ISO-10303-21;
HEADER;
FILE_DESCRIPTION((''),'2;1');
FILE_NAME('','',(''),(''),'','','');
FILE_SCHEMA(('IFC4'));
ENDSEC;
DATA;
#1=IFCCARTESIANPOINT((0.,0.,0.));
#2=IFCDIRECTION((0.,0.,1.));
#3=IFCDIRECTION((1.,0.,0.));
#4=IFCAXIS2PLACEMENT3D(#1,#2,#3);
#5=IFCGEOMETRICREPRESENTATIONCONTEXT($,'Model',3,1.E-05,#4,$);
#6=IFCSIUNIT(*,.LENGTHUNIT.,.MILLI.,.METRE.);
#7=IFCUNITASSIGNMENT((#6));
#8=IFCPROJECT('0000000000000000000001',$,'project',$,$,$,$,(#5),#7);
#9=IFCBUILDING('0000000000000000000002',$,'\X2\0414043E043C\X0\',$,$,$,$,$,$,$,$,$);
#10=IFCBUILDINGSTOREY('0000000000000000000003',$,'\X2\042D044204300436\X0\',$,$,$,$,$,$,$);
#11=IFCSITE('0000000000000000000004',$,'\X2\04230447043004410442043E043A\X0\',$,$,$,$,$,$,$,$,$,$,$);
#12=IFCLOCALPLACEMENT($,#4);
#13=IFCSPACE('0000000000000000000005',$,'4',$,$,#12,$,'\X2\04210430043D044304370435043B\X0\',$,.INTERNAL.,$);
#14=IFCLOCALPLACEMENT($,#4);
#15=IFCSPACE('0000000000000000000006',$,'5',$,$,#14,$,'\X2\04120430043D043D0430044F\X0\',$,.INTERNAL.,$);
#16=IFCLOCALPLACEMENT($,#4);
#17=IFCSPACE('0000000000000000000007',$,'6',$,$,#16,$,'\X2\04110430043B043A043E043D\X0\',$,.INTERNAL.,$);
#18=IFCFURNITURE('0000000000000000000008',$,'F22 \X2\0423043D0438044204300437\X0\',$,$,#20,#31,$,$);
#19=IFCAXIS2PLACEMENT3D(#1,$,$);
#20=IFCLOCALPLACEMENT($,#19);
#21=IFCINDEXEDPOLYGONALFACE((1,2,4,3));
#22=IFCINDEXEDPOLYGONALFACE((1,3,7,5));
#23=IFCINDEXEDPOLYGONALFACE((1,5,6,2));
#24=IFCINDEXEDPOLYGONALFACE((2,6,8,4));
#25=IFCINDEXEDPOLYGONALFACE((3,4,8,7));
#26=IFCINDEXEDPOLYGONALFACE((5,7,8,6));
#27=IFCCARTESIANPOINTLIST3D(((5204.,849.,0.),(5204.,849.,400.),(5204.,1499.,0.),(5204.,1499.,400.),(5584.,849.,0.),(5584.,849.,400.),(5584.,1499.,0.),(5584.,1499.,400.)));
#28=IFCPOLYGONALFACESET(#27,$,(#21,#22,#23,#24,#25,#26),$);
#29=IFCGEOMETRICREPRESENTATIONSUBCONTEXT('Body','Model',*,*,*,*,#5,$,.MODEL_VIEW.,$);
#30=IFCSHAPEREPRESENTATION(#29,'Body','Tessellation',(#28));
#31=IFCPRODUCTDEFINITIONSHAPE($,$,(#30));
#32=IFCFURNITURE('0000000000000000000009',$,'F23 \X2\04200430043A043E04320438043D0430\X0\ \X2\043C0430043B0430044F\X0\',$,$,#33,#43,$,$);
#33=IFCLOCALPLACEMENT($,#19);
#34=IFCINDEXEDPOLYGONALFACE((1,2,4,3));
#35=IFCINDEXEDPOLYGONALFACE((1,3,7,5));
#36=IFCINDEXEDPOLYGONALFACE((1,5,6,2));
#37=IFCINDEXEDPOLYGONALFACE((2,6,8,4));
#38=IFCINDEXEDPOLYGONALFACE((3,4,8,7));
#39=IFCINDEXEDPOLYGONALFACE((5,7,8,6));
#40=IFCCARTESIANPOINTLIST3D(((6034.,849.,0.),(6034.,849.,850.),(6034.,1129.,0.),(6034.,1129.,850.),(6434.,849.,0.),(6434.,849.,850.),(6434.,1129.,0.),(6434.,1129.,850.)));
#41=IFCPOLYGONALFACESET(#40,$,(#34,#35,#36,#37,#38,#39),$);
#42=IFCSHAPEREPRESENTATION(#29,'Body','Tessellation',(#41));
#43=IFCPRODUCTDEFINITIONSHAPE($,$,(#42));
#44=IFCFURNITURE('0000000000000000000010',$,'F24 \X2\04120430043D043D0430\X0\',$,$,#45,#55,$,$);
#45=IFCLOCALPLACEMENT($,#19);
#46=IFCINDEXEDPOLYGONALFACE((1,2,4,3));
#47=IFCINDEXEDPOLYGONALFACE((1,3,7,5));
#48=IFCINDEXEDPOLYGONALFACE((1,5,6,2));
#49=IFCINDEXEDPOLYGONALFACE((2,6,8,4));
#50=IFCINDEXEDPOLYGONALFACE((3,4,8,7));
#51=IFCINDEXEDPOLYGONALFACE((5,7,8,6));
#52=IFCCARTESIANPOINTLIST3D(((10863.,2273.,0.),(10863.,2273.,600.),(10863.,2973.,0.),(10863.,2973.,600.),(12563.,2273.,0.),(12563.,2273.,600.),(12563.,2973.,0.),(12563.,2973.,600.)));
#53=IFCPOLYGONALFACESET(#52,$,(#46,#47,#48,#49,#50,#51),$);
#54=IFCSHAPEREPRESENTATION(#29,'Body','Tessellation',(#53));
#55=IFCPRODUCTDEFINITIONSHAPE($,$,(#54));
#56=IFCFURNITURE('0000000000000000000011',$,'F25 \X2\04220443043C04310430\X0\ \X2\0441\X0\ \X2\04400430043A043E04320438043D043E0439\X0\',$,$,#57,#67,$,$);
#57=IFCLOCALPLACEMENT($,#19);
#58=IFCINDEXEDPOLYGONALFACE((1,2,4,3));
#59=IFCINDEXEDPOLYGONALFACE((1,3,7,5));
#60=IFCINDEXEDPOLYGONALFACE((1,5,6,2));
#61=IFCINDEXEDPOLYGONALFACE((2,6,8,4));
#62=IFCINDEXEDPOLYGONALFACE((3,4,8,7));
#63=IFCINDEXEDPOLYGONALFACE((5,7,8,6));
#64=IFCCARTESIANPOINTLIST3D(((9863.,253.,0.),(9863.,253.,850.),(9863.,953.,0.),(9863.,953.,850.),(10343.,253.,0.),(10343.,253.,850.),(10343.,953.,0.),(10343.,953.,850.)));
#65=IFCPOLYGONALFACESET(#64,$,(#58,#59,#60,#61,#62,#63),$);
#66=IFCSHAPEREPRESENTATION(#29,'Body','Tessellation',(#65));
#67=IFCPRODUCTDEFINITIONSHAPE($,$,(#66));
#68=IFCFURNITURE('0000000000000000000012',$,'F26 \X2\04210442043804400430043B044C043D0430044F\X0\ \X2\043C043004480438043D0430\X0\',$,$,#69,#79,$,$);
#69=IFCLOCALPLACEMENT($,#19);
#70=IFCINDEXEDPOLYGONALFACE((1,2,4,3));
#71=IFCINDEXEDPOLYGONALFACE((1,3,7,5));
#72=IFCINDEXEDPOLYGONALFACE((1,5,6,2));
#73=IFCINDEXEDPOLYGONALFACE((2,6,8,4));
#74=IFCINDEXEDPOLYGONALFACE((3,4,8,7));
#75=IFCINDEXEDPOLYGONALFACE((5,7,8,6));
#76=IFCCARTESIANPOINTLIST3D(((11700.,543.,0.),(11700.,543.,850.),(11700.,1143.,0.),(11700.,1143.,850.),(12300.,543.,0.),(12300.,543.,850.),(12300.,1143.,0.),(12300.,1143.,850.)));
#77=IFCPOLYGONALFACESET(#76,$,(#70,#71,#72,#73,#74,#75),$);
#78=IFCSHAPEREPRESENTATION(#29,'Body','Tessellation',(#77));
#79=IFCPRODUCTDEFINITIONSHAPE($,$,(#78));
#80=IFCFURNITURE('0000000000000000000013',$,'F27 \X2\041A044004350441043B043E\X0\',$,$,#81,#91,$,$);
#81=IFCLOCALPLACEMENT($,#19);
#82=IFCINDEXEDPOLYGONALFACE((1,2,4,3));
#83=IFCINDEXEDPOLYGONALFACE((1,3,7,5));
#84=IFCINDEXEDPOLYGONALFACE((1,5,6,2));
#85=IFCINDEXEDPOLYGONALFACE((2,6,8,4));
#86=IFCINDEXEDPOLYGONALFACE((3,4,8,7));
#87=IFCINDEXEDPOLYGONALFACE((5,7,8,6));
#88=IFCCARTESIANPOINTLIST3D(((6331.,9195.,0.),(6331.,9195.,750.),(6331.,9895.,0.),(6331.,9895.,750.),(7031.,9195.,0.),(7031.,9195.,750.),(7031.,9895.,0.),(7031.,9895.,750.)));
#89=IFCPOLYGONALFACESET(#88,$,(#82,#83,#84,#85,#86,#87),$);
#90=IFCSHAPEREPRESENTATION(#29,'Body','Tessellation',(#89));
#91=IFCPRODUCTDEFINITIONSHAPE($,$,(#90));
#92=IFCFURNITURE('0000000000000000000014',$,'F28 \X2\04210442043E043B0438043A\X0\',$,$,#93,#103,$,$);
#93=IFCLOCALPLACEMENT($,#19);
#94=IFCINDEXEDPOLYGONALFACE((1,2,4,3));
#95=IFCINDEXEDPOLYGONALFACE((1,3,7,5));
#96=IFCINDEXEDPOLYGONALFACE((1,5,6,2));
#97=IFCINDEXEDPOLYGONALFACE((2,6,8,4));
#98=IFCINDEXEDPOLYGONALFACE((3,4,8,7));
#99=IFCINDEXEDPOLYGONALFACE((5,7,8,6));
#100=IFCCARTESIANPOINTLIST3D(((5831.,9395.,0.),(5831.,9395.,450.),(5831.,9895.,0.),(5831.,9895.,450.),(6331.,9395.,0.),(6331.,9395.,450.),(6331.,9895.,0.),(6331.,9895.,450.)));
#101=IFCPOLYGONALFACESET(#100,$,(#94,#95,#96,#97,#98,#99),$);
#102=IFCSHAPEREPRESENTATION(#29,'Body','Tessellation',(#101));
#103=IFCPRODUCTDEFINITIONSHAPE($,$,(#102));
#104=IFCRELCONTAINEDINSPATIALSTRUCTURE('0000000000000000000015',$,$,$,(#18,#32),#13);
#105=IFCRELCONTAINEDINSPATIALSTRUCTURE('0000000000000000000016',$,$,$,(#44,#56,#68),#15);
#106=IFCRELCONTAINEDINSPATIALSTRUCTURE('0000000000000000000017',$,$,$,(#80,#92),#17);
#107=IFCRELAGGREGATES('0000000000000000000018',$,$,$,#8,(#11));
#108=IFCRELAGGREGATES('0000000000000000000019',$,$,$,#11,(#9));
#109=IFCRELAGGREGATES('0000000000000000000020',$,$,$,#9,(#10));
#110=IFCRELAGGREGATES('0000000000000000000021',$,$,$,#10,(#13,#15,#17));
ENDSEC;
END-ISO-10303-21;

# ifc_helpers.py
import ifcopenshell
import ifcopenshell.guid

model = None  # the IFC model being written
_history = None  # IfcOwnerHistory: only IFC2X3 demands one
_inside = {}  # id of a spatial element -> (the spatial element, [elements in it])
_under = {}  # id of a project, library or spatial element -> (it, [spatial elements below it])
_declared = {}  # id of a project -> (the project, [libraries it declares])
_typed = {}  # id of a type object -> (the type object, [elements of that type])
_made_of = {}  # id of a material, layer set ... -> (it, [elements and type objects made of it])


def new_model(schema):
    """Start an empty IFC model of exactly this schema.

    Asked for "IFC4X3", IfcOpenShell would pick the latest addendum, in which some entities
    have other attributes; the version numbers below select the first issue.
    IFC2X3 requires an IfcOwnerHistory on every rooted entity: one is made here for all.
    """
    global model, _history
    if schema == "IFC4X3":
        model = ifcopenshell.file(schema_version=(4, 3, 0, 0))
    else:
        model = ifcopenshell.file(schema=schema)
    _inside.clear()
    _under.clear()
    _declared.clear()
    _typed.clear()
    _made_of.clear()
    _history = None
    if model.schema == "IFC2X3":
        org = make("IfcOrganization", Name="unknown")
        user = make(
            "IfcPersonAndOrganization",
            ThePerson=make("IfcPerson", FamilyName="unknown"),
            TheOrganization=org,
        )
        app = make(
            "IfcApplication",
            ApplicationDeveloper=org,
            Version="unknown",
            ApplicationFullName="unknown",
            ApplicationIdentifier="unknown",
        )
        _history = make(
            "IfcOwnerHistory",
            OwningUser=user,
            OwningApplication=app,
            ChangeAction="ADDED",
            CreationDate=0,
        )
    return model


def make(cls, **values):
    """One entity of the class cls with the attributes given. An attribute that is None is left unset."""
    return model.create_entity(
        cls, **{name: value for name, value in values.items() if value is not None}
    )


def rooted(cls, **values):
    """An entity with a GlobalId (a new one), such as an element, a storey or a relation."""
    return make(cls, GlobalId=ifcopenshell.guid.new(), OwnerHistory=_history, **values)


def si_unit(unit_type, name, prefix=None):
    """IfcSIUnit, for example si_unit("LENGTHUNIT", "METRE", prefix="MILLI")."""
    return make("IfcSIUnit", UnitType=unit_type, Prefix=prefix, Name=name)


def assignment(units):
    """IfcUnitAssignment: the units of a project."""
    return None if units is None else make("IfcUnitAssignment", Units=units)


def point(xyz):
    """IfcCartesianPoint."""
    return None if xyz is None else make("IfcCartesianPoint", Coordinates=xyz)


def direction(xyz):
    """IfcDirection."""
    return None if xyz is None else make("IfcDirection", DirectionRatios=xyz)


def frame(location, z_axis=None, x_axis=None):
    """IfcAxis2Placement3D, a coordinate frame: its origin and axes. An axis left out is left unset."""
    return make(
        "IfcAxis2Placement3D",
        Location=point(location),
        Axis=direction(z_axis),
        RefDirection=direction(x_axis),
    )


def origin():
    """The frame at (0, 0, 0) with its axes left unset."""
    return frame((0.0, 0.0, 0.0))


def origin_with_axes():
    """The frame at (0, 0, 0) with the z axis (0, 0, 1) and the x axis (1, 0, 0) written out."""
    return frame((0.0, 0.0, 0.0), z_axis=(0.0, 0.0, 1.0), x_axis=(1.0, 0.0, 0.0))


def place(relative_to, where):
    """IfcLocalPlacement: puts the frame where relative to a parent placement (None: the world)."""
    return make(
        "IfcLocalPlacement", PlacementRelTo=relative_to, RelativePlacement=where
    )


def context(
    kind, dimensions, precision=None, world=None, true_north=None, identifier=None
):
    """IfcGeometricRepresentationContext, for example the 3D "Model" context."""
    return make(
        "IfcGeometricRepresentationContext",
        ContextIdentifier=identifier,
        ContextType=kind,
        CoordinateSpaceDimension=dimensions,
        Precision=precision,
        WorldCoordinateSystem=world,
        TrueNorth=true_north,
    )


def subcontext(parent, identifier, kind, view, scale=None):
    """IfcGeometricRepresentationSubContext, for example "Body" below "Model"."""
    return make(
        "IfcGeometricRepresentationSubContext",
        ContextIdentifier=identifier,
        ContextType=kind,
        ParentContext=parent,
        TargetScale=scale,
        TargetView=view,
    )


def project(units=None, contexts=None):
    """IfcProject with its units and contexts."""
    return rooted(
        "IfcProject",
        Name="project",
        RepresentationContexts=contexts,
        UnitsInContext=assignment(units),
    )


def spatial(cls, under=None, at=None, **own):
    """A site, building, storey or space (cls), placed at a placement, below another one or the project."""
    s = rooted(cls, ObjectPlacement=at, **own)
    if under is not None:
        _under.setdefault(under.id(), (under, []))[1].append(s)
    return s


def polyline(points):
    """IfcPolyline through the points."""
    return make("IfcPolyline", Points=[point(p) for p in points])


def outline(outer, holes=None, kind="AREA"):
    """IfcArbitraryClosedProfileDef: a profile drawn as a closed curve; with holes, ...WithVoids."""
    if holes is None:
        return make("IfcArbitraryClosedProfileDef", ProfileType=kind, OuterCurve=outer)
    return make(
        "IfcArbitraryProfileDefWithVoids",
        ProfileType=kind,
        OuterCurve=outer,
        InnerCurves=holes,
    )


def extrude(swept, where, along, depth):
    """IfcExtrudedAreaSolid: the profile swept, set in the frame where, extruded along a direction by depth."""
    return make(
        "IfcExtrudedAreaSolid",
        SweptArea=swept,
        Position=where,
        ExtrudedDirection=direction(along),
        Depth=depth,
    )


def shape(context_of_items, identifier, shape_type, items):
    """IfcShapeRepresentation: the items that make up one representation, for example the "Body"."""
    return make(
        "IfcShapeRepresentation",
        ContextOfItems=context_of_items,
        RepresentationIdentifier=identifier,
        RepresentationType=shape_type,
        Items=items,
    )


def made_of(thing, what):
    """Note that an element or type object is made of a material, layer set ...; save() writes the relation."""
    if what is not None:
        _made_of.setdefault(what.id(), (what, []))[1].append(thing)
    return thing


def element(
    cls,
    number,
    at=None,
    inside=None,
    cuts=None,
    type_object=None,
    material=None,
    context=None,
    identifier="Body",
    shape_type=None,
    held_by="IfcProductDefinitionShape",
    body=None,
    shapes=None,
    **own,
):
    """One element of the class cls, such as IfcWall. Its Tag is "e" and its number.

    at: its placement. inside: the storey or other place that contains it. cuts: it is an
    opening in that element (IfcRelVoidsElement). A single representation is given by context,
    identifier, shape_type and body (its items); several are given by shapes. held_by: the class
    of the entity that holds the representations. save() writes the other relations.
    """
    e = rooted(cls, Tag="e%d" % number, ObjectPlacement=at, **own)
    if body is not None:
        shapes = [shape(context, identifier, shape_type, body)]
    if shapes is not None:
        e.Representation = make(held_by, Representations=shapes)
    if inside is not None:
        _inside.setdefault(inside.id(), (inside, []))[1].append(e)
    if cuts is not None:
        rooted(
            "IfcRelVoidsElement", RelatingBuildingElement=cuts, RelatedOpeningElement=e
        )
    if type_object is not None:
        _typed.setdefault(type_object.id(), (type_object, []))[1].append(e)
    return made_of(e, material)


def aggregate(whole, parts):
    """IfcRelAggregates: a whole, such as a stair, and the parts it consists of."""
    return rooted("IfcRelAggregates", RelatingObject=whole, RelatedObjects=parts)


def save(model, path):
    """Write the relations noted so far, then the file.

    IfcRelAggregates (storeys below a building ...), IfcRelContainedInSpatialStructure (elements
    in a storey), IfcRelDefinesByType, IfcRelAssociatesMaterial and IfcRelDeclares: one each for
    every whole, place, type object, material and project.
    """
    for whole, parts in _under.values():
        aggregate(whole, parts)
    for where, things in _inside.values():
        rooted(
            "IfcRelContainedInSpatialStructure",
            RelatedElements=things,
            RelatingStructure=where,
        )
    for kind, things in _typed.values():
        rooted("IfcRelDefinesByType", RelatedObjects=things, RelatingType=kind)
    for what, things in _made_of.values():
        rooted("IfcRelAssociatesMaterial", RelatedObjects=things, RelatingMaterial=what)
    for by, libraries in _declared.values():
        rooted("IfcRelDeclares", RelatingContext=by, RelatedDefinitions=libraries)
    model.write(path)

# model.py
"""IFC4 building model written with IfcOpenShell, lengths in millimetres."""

from ifc_helpers import new_model, si_unit, origin, origin_with_axes, place, context, subcontext, project, spatial, polyline, outline, extrude, element, save


model = new_model("IFC4")

# Units and contexts
model_context = context("Model", 3, precision=1e-05, world=origin_with_axes())
body_context = subcontext(model_context, "Body", "Model", "MODEL_VIEW")
ifc_project = project(units=[si_unit("LENGTHUNIT", "METRE", prefix="MILLI")], contexts=[model_context])

# Site, building, storey
site = spatial("IfcSite", under=ifc_project, Name="Участок")
building = spatial("IfcBuilding", under=site, Name="Дом")
storey = spatial("IfcBuildingStorey", under=building, Name="Этаж")

# Shared definitions
space_1_placement = place(None, origin_with_axes())
space_1 = spatial("IfcSpace", under=storey, at=space_1_placement, Name="4", LongName="Санузел", PredefinedType="INTERNAL")

# Furniture
furniture_1_placement = place(space_1_placement, origin_with_axes())
element("IfcFurniture", 1, at=furniture_1_placement, inside=space_1, Name="F22 Унитаз", context=body_context, shape_type="SweptSolid", body=[
    extrude(outline(polyline([(5584.0, 849.0), (5204.0, 849.0), (5204.0, 1499.0), (5584.0, 1499.0), (5584.0, 849.0)])), origin(), (0.0, 0.0, 1.0), 400.0),
])
furniture_2_placement = place(space_1_placement, origin_with_axes())
element("IfcFurniture", 2, at=furniture_2_placement, inside=space_1, Name="F23 Раковина малая", context=body_context, shape_type="SweptSolid", body=[
    extrude(outline(polyline([(6434.0, 849.0), (6034.0, 849.0), (6034.0, 1129.0), (6434.0, 1129.0), (6434.0, 849.0)])), origin(), (0.0, 0.0, 1.0), 850.0),
])

# Shared definitions
space_2_placement = place(None, origin_with_axes())
space_2 = spatial("IfcSpace", under=storey, at=space_2_placement, Name="5", LongName="Ванная", PredefinedType="INTERNAL")

# Furniture
furniture_3_placement = place(space_2_placement, origin_with_axes())
element("IfcFurniture", 3, at=furniture_3_placement, inside=space_2, Name="F24 Ванна", context=body_context, shape_type="SweptSolid", body=[
    extrude(outline(polyline([(10863.0, 2973.0), (12563.0, 2973.0), (12563.0, 2273.0), (10863.0, 2273.0), (10863.0, 2973.0)])), origin(), (0.0, 0.0, 1.0), 600.0),
])
furniture_4_placement = place(space_2_placement, origin_with_axes())
element("IfcFurniture", 4, at=furniture_4_placement, inside=space_2, Name="F25 Тумба с раковиной", context=body_context, shape_type="SweptSolid", body=[
    extrude(outline(polyline([(9863.0, 253.0), (9863.0, 953.0), (10343.0, 953.0), (10343.0, 253.0), (9863.0, 253.0)])), origin(), (0.0, 0.0, 1.0), 850.0),
])
furniture_5_placement = place(space_2_placement, origin_with_axes())
element("IfcFurniture", 5, at=furniture_5_placement, inside=space_2, Name="F26 Стиральная машина", context=body_context, shape_type="SweptSolid", body=[
    extrude(outline(polyline([(12300.0, 543.0), (11700.0, 543.0), (11700.0, 1143.0), (12300.0, 1143.0), (12300.0, 543.0)])), origin(), (0.0, 0.0, 1.0), 850.0),
])

# Shared definitions
space_3_placement = place(None, origin_with_axes())
space_3 = spatial("IfcSpace", under=storey, at=space_3_placement, Name="6", LongName="Балкон", PredefinedType="INTERNAL")

# Furniture
furniture_6_placement = place(space_3_placement, origin_with_axes())
element("IfcFurniture", 6, at=furniture_6_placement, inside=space_3, Name="F27 Кресло", context=body_context, shape_type="SweptSolid", body=[
    extrude(outline(polyline([(6331.0, 9895.0), (7031.0, 9895.0), (7031.0, 9195.0), (6331.0, 9195.0), (6331.0, 9895.0)])), origin(), (0.0, 0.0, 1.0), 750.0),
])
furniture_7_placement = place(space_3_placement, origin_with_axes())
element("IfcFurniture", 7, at=furniture_7_placement, inside=space_3, Name="F28 Столик", context=body_context, shape_type="SweptSolid", body=[
    extrude(outline(polyline([(5831.0, 9895.0), (6331.0, 9895.0), (6331.0, 9395.0), (5831.0, 9395.0), (5831.0, 9895.0)])), origin(), (0.0, 0.0, 1.0), 450.0),
])

save(model, "model.ifc")
